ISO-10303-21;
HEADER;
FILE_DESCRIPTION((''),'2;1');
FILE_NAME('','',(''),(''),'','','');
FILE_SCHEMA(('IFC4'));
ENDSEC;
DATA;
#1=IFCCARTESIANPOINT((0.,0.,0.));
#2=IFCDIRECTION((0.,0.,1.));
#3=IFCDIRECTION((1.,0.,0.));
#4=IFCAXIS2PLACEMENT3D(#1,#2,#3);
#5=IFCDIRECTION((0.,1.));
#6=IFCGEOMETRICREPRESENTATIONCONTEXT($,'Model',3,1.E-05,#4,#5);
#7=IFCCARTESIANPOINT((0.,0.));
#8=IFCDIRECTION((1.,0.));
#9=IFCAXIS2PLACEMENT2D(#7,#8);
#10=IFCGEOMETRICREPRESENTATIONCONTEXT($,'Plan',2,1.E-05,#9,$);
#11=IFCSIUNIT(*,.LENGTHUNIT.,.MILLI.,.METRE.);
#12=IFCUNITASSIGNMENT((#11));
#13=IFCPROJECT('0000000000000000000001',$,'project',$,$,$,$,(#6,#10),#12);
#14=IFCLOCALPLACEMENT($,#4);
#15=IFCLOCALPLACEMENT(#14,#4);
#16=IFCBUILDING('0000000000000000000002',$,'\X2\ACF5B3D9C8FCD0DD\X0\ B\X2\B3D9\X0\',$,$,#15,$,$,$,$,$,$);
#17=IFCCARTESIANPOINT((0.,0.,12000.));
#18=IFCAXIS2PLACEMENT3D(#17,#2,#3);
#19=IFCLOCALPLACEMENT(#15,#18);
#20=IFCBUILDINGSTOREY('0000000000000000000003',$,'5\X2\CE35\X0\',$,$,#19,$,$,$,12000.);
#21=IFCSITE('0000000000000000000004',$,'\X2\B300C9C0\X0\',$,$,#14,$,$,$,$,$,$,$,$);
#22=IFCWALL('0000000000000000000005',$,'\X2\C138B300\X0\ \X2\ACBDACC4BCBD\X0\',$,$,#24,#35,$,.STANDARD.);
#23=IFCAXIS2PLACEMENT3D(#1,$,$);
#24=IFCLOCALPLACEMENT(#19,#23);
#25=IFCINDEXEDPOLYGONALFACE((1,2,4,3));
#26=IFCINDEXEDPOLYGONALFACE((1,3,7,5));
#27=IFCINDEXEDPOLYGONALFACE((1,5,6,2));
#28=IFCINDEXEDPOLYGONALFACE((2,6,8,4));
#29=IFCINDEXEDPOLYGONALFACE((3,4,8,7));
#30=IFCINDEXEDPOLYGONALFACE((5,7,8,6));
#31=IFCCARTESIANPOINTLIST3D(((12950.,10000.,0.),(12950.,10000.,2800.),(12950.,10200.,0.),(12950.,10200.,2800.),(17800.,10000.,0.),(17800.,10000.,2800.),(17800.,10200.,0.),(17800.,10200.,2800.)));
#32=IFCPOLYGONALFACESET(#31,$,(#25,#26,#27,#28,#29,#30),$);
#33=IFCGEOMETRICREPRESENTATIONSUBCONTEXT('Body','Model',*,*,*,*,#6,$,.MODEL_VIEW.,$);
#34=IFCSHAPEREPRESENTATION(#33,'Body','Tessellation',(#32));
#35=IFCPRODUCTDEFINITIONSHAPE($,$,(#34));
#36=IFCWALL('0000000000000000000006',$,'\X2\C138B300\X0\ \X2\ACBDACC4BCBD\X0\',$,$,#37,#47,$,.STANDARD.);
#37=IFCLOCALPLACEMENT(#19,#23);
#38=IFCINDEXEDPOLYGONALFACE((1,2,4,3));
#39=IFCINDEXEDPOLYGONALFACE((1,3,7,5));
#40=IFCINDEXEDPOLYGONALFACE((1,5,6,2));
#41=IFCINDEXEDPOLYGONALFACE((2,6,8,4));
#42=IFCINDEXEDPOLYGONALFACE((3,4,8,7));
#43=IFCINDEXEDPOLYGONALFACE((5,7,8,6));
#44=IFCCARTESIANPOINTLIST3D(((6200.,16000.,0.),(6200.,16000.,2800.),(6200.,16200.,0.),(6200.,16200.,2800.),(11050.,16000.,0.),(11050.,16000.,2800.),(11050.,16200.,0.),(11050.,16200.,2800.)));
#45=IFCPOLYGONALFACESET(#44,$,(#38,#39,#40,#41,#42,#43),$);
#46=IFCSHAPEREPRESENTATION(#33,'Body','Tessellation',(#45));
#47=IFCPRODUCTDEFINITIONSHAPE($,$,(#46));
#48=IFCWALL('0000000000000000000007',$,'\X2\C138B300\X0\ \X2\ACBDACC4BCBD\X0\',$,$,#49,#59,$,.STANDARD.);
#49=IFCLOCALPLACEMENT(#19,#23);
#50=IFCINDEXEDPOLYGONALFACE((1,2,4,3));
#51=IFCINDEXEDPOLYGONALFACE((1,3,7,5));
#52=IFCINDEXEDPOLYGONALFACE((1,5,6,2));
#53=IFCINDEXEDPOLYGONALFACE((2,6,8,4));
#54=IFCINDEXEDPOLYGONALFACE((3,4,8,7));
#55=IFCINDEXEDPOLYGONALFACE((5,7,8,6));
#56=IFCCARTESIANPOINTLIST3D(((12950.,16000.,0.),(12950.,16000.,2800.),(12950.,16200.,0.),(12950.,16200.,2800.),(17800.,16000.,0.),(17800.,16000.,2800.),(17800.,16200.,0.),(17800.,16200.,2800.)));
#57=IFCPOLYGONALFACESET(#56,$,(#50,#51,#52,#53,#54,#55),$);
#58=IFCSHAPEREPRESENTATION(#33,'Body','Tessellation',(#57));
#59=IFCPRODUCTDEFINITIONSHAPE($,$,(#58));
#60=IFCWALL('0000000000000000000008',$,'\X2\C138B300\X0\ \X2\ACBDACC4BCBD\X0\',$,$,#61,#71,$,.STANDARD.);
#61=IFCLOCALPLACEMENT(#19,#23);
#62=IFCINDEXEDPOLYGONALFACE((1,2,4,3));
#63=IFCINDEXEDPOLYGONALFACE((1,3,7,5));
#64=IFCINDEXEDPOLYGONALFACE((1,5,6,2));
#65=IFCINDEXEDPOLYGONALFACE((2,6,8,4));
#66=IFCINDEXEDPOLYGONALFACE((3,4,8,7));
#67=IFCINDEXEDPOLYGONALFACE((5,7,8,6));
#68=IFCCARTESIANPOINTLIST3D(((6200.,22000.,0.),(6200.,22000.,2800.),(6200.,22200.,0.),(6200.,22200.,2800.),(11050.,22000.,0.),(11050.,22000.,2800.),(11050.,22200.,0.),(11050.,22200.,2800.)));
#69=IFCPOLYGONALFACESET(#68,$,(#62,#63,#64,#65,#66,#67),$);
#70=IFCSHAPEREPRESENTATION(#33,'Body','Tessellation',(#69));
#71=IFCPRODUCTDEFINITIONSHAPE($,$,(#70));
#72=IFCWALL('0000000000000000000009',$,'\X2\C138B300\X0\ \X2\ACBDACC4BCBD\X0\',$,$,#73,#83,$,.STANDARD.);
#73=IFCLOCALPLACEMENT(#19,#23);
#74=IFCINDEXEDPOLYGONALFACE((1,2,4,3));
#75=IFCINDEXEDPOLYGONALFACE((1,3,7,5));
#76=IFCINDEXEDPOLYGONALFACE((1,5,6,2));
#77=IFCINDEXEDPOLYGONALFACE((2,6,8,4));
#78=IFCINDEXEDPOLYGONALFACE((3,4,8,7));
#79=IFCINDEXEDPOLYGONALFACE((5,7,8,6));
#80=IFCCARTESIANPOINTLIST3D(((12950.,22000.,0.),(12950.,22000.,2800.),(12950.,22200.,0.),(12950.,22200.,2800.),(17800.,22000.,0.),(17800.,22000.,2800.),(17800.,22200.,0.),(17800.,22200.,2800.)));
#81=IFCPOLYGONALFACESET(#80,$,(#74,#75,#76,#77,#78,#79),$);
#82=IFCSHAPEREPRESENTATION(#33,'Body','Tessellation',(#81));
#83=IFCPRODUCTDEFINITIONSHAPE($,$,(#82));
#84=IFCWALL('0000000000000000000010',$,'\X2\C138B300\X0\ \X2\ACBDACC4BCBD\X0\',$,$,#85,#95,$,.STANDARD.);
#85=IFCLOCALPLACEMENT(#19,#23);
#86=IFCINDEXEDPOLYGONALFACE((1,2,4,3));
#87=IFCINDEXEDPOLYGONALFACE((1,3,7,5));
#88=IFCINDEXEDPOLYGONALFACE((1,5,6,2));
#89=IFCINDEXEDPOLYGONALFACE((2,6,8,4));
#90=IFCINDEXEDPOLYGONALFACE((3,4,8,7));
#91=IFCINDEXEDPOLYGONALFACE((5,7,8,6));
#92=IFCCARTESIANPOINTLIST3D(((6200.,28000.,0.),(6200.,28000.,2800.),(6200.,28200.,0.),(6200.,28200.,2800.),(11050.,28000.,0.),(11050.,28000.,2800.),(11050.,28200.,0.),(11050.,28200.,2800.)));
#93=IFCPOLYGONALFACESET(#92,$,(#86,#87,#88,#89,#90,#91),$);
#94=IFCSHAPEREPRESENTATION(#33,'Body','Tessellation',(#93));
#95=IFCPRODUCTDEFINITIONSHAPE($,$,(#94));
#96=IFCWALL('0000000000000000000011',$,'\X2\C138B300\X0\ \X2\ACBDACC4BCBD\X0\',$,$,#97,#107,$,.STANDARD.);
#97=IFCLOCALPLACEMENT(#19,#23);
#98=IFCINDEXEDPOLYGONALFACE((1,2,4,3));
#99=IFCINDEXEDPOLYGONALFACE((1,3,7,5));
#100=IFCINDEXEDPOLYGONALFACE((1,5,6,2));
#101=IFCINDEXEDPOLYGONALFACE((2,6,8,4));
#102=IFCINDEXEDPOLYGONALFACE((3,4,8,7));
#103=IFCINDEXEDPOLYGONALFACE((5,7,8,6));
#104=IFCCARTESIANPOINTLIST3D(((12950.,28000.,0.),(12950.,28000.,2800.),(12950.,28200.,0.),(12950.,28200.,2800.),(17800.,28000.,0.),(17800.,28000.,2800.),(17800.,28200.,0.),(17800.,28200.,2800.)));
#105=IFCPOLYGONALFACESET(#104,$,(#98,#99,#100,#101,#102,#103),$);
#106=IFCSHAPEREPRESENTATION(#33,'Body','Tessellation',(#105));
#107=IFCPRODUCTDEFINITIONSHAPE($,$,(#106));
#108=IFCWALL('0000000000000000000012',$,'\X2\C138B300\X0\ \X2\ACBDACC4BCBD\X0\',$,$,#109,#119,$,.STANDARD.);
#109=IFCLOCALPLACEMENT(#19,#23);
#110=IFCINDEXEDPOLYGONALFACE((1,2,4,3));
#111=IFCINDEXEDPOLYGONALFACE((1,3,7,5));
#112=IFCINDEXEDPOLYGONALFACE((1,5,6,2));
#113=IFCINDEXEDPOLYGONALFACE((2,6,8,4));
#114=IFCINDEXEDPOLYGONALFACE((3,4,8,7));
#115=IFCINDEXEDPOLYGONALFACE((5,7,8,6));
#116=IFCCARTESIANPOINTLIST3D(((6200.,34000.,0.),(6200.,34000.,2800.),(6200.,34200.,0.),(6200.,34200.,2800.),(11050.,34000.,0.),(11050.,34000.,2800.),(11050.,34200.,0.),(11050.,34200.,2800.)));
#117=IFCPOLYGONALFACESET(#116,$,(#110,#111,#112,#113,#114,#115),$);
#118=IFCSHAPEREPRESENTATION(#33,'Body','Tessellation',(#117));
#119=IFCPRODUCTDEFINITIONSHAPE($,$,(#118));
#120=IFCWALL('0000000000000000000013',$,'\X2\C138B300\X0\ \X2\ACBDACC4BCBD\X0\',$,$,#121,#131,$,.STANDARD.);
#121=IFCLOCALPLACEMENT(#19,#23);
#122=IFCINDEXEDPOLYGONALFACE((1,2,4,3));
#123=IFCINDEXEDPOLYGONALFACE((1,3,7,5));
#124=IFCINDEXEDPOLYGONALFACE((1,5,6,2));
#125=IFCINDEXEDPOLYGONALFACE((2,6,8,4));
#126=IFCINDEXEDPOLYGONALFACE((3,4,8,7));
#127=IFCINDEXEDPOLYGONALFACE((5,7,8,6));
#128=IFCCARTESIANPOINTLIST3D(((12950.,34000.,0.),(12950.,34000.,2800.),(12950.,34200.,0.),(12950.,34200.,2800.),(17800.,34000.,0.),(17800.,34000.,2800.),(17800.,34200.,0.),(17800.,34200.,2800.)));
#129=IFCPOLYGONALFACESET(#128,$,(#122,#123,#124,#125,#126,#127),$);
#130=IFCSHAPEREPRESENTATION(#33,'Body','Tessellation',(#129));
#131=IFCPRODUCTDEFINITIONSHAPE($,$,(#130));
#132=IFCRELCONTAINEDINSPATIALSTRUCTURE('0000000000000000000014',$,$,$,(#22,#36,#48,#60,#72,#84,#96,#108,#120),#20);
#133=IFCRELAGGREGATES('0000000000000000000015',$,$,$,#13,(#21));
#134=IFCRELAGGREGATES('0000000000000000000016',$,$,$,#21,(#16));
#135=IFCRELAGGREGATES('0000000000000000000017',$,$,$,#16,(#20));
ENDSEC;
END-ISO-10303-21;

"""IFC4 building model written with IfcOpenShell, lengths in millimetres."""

from ifc_helpers import new_model, si_unit, direction, frame, origin_with_axes, origin_2d_with_axis, place, context, subcontext, project, spatial, polyline, outline, extrude, element, save


model = new_model("IFC4")

# Units and contexts
model_context = context("Model", 3, precision=1e-05, world=origin_with_axes(), true_north=direction((0.0, 1.0)))
plan_context = context("Plan", 2, precision=1e-05, world=origin_2d_with_axis())
body_context = subcontext(model_context, "Body", "Model", "MODEL_VIEW")
ifc_project = project(units=[si_unit("LENGTHUNIT", "METRE", prefix="MILLI")], contexts=[model_context, plan_context])

# Site, building, storey
site_placement = place(None, origin_with_axes())
site = spatial("IfcSite", under=ifc_project, at=site_placement, Name="대지")
building_placement = place(site_placement, origin_with_axes())
building = spatial("IfcBuilding", under=site, at=building_placement, Name="공동주택 B동")
storey_placement = place(building_placement, frame((0.0, 0.0, 12000.0), z_axis=(0.0, 0.0, 1.0), x_axis=(1.0, 0.0, 0.0)))
storey = spatial("IfcBuildingStorey", under=building, at=storey_placement, Name="5층", Elevation=12000.0)

# Walls
wall_1_placement = place(storey_placement, origin_with_axes())
element("IfcWall", 1, at=wall_1_placement, inside=storey, Name="세대 경계벽", PredefinedType="STANDARD", context=body_context, shape_type="SweptSolid", body=[
    extrude(outline(polyline([(12950.0, 10200.0), (17800.0, 10200.0), (17800.0, 10000.0), (12950.0, 10000.0), (12950.0, 10200.0)])), origin_with_axes(), (0.0, 0.0, 1.0), 2800.0),
])
wall_2_placement = place(storey_placement, origin_with_axes())
element("IfcWall", 2, at=wall_2_placement, inside=storey, Name="세대 경계벽", PredefinedType="STANDARD", context=body_context, shape_type="SweptSolid", body=[
    extrude(outline(polyline([(6200.0, 16200.0), (11050.0, 16200.0), (11050.0, 16000.0), (6200.0, 16000.0), (6200.0, 16200.0)])), origin_with_axes(), (0.0, 0.0, 1.0), 2800.0),
])
wall_3_placement = place(storey_placement, origin_with_axes())
element("IfcWall", 3, at=wall_3_placement, inside=storey, Name="세대 경계벽", PredefinedType="STANDARD", context=body_context, shape_type="SweptSolid", body=[
    extrude(outline(polyline([(12950.0, 16200.0), (17800.0, 16200.0), (17800.0, 16000.0), (12950.0, 16000.0), (12950.0, 16200.0)])), origin_with_axes(), (0.0, 0.0, 1.0), 2800.0),
])
wall_4_placement = place(storey_placement, origin_with_axes())
element("IfcWall", 4, at=wall_4_placement, inside=storey, Name="세대 경계벽", PredefinedType="STANDARD", context=body_context, shape_type="SweptSolid", body=[
    extrude(outline(polyline([(6200.0, 22200.0), (11050.0, 22200.0), (11050.0, 22000.0), (6200.0, 22000.0), (6200.0, 22200.0)])), origin_with_axes(), (0.0, 0.0, 1.0), 2800.0),
])
wall_5_placement = place(storey_placement, origin_with_axes())
element("IfcWall", 5, at=wall_5_placement, inside=storey, Name="세대 경계벽", PredefinedType="STANDARD", context=body_context, shape_type="SweptSolid", body=[
    extrude(outline(polyline([(12950.0, 22200.0), (17800.0, 22200.0), (17800.0, 22000.0), (12950.0, 22000.0), (12950.0, 22200.0)])), origin_with_axes(), (0.0, 0.0, 1.0), 2800.0),
])
wall_6_placement = place(storey_placement, origin_with_axes())
element("IfcWall", 6, at=wall_6_placement, inside=storey, Name="세대 경계벽", PredefinedType="STANDARD", context=body_context, shape_type="SweptSolid", body=[
    extrude(outline(polyline([(6200.0, 28200.0), (11050.0, 28200.0), (11050.0, 28000.0), (6200.0, 28000.0), (6200.0, 28200.0)])), origin_with_axes(), (0.0, 0.0, 1.0), 2800.0),
])
wall_7_placement = place(storey_placement, origin_with_axes())
element("IfcWall", 7, at=wall_7_placement, inside=storey, Name="세대 경계벽", PredefinedType="STANDARD", context=body_context, shape_type="SweptSolid", body=[
    extrude(outline(polyline([(12950.0, 28200.0), (17800.0, 28200.0), (17800.0, 28000.0), (12950.0, 28000.0), (12950.0, 28200.0)])), origin_with_axes(), (0.0, 0.0, 1.0), 2800.0),
])
wall_8_placement = place(storey_placement, origin_with_axes())
element("IfcWall", 8, at=wall_8_placement, inside=storey, Name="세대 경계벽", PredefinedType="STANDARD", context=body_context, shape_type="SweptSolid", body=[
    extrude(outline(polyline([(6200.0, 34200.0), (11050.0, 34200.0), (11050.0, 34000.0), (6200.0, 34000.0), (6200.0, 34200.0)])), origin_with_axes(), (0.0, 0.0, 1.0), 2800.0),
])
wall_9_placement = place(storey_placement, origin_with_axes())
element("IfcWall", 9, at=wall_9_placement, inside=storey, Name="세대 경계벽", PredefinedType="STANDARD", context=body_context, shape_type="SweptSolid", body=[
    extrude(outline(polyline([(12950.0, 34200.0), (17800.0, 34200.0), (17800.0, 34000.0), (12950.0, 34000.0), (12950.0, 34200.0)])), origin_with_axes(), (0.0, 0.0, 1.0), 2800.0),
])

save(model, "model.ifc")
